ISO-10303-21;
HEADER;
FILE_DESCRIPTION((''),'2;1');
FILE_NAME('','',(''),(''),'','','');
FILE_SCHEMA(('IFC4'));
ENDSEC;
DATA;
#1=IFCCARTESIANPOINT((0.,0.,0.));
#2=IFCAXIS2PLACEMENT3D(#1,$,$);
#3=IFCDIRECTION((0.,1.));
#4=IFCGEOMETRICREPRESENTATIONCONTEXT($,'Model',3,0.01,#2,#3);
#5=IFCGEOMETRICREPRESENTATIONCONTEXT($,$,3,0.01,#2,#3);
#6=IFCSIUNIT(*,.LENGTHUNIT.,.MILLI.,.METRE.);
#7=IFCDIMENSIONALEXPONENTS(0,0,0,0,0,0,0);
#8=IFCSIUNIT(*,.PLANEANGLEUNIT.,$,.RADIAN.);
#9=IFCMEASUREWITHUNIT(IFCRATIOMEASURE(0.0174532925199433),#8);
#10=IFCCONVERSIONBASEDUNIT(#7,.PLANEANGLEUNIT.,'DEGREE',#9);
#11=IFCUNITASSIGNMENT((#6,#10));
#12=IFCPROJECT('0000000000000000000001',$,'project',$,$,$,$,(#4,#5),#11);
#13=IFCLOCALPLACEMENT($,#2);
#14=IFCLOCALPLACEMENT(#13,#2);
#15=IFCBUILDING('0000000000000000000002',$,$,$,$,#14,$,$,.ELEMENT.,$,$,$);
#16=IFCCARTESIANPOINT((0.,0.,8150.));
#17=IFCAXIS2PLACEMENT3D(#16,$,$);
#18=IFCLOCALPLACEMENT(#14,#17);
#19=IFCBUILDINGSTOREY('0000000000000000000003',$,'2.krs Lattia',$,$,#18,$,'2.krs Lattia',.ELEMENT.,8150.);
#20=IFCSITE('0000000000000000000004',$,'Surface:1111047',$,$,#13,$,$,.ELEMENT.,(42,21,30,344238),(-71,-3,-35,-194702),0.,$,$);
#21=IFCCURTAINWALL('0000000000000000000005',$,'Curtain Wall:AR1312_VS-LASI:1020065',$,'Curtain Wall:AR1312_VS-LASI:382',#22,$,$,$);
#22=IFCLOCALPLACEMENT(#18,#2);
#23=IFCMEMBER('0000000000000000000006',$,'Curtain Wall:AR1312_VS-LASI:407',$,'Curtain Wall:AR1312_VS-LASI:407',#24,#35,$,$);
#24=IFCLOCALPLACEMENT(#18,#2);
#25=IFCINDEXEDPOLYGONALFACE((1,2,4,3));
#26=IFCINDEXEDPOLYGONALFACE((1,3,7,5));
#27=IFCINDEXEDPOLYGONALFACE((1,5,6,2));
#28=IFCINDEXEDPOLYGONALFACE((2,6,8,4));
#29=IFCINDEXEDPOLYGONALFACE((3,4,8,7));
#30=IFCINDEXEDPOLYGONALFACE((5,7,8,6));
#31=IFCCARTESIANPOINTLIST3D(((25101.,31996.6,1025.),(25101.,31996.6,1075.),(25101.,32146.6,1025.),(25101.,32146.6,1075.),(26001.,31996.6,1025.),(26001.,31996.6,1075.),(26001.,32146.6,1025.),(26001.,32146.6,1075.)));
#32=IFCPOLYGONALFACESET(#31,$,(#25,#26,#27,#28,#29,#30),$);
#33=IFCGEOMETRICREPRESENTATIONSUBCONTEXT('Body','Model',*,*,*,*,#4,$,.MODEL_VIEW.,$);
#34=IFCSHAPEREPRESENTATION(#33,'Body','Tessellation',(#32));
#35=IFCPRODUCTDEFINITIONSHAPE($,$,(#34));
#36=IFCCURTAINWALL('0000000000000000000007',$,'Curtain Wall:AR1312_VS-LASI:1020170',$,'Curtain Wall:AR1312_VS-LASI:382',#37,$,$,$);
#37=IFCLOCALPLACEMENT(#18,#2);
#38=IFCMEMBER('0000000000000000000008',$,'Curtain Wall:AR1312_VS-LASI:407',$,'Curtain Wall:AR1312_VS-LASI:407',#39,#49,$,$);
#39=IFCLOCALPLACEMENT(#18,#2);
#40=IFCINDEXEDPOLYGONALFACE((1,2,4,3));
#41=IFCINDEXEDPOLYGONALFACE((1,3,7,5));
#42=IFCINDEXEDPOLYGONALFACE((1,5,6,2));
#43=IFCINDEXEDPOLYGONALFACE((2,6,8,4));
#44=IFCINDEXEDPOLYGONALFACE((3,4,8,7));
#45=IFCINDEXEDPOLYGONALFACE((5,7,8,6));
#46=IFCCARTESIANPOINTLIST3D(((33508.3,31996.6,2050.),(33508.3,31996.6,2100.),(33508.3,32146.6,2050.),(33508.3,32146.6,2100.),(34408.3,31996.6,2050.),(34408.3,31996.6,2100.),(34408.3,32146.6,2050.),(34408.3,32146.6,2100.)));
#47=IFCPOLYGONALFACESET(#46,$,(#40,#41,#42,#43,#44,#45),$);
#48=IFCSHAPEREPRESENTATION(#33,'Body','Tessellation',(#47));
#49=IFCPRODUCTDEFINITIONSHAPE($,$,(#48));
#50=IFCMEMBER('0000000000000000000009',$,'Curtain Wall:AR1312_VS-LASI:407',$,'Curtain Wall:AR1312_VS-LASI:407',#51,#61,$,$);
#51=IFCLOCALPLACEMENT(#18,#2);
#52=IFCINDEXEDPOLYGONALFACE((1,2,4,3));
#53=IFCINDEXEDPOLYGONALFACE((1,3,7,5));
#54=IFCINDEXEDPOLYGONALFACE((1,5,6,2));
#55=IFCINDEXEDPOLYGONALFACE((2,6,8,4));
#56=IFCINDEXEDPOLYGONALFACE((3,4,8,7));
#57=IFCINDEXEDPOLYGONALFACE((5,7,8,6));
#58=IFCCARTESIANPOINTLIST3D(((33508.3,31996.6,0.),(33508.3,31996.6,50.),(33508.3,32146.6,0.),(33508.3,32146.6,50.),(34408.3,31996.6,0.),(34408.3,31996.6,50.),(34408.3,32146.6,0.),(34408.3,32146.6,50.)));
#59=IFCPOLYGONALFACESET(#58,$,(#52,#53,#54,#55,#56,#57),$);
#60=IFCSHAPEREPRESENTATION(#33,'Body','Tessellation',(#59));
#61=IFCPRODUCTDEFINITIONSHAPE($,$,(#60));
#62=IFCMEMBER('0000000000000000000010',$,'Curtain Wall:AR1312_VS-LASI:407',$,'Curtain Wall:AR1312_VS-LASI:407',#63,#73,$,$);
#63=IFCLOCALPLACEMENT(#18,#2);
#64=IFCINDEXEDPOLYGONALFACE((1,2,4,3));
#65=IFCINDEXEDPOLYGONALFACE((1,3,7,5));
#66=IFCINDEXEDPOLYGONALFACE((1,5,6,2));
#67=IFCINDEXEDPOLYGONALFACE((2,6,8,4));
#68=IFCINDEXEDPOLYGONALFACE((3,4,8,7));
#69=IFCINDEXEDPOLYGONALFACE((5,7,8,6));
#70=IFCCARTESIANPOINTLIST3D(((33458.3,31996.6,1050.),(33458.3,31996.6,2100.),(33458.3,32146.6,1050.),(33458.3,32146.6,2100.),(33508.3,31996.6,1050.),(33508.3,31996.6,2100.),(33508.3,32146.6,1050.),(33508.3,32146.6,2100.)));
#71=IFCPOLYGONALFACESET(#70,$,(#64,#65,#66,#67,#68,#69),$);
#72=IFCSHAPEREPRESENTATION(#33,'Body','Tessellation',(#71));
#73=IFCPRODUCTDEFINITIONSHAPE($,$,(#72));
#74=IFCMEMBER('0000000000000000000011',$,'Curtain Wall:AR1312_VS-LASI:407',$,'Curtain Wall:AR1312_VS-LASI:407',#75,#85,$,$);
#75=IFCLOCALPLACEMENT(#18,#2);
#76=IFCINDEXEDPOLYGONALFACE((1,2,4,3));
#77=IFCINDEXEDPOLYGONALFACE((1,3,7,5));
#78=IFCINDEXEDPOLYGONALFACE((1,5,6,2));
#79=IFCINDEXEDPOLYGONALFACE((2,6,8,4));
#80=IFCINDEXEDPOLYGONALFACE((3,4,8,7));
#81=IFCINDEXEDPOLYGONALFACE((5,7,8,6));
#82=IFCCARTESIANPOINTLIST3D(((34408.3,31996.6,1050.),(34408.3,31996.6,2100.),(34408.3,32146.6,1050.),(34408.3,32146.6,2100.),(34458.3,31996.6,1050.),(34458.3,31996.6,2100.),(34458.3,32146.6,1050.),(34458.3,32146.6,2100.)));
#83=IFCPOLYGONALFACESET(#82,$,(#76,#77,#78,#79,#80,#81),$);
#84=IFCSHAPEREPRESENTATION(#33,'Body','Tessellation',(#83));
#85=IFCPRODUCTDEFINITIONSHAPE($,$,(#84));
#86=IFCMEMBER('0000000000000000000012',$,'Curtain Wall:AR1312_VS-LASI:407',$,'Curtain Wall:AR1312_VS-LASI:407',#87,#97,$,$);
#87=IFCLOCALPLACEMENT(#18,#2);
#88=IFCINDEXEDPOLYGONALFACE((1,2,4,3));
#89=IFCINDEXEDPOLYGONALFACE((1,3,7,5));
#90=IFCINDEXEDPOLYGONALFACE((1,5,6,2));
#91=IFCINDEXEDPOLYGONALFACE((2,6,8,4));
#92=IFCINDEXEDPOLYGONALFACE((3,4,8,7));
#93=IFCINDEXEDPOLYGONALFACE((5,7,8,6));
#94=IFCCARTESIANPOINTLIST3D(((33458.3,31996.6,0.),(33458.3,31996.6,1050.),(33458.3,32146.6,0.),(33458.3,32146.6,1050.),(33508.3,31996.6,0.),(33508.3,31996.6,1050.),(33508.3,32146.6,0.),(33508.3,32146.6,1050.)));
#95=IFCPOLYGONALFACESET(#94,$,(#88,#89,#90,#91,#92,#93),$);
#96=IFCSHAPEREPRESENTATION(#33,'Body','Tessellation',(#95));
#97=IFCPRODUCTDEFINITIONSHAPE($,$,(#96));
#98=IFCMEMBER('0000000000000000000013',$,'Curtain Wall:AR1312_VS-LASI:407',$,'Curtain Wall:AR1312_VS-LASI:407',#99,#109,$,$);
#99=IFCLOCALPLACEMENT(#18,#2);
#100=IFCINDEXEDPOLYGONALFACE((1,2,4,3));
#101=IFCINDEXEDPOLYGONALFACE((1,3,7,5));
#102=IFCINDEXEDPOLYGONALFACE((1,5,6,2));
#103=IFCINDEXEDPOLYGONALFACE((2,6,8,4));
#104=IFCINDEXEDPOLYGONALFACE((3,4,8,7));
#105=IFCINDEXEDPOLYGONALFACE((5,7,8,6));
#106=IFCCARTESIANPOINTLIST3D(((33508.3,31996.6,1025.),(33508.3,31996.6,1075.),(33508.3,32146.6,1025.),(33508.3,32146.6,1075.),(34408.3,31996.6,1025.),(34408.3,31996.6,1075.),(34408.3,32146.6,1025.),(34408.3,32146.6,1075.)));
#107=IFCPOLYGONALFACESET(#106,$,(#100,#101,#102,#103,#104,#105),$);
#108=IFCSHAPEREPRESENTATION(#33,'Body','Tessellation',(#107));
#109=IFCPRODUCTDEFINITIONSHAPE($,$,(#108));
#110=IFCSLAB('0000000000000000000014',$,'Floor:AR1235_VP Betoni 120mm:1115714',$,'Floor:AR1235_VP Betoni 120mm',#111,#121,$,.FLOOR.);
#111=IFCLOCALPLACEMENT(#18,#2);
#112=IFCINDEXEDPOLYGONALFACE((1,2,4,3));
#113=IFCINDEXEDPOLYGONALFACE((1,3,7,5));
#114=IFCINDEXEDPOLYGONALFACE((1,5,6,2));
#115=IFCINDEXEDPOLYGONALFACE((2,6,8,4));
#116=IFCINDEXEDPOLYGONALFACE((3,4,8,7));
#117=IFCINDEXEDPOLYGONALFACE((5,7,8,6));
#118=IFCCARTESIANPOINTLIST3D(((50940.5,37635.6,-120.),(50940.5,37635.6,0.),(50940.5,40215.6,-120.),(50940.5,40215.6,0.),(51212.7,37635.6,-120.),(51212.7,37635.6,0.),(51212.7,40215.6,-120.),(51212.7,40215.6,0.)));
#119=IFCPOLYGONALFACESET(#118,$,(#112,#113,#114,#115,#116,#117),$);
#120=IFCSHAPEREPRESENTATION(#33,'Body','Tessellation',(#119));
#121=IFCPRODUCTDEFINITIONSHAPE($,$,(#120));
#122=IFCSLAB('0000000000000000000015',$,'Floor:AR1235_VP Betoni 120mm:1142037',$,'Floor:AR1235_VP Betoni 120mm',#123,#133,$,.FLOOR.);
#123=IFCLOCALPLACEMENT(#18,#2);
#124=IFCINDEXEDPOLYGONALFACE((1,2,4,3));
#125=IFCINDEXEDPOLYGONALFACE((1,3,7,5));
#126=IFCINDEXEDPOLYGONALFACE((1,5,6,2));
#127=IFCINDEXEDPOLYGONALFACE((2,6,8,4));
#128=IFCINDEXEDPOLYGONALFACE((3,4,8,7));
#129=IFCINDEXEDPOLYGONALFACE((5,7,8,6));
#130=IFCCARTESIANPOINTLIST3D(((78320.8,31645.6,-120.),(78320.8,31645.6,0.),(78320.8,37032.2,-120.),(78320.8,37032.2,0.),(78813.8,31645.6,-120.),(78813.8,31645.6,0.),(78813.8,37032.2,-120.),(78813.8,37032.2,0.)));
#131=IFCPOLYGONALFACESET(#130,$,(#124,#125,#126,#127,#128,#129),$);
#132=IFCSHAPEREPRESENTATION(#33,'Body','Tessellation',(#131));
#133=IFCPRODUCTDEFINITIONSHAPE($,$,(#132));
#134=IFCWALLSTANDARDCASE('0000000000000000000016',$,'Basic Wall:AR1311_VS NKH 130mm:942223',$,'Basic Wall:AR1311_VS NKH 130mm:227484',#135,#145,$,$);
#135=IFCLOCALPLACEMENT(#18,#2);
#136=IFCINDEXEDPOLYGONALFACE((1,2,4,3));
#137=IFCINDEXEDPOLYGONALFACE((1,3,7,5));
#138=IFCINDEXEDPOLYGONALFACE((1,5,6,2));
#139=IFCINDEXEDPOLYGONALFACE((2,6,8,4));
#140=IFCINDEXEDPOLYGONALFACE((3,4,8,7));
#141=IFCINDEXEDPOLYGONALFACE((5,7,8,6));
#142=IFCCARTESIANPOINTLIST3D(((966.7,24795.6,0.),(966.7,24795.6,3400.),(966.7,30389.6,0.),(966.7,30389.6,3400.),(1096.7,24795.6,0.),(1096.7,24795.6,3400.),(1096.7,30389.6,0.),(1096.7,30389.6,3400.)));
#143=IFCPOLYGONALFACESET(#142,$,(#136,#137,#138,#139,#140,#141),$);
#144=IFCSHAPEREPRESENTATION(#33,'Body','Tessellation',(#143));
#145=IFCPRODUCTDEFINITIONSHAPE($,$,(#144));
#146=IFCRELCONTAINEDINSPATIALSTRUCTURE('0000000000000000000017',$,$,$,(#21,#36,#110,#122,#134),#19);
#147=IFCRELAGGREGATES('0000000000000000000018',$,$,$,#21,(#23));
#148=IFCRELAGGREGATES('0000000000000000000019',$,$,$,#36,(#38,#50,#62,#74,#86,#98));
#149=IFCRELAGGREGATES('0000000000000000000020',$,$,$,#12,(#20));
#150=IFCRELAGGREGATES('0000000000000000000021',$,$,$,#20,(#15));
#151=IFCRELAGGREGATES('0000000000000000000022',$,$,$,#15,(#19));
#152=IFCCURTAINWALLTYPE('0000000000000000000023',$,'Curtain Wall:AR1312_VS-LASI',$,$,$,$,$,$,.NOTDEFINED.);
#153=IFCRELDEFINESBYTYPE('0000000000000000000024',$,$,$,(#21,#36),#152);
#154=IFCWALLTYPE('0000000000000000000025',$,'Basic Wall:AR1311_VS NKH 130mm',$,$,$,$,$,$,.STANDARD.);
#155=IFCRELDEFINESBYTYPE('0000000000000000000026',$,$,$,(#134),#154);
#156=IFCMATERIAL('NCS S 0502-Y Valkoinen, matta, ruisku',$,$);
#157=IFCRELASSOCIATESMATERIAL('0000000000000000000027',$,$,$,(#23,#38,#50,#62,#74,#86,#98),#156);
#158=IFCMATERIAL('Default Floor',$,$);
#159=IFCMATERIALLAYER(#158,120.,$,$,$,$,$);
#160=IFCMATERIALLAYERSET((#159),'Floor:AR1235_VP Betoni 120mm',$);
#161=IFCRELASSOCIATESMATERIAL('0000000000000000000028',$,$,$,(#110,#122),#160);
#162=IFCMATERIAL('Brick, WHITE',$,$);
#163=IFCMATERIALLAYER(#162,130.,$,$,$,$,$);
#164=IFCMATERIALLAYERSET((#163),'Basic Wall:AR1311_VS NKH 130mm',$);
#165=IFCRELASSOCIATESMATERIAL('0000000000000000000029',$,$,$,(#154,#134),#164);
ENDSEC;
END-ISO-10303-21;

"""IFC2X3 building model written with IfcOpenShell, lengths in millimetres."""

from ifc_helpers import new_model, entity, si_unit, converted_unit, direction, frame, frame_2d, origin, place, context, subcontext, project, spatial, rectangle, extrude, material, layer, layer_set, layer_usage, type_object, element, aggregate, save


model = new_model("IFC2X3")

# Units and contexts
model_context = context("Model", 3, precision=0.01, world=origin(), true_north=direction((0.0, 1.0)))
context_of_model = context(None, 3, precision=0.01, world=origin(), true_north=direction((0.0, 1.0)))
body_context = subcontext(model_context, "Body", "Model", "MODEL_VIEW")
ifc_project = project(units=[si_unit("LENGTHUNIT", "METRE", prefix="MILLI"), converted_unit("PLANEANGLEUNIT", "DEGREE", entity("IfcRatioMeasure", 0.0174532925199433), si_unit("PLANEANGLEUNIT", "RADIAN"), dimensions=[0, 0, 0, 0, 0, 0, 0])], contexts=[model_context, context_of_model])

# Site, building, storey
site_placement = place(None, origin())
site = spatial("IfcSite", under=ifc_project, at=site_placement, Name="Surface:1111047", CompositionType="ELEMENT", RefLatitude=(42, 21, 30, 344238), RefLongitude=(-71, -3, -35, -194702), RefElevation=0.0)
building_placement = place(site_placement, origin())
building = spatial("IfcBuilding", under=site, at=building_placement, CompositionType="ELEMENT")
storey_placement = place(building_placement, frame((0.0, 0.0, 8150.0)))
storey = spatial("IfcBuildingStorey", under=building, at=storey_placement, Name="2.krs Lattia", LongName="2.krs Lattia", CompositionType="ELEMENT", Elevation=8150.0)

# Curtain walls, members
curtain_wall_type = type_object("IfcCurtainWallType", Name="Curtain Wall:AR1312_VS-LASI", PredefinedType="NOTDEFINED")
ifc_material_1 = material(Name="NCS S 0502-Y Valkoinen, matta, ruisku")
curtain_wall_1_placement = place(storey_placement, frame((0.0, 0.0, -8150.0)))
curtain_wall_1 = element("IfcCurtainWall", 1, at=curtain_wall_1_placement, inside=storey, type_object=curtain_wall_type, Name="Curtain Wall:AR1312_VS-LASI:1020065", ObjectType="Curtain Wall:AR1312_VS-LASI:382")
member_1_placement = place(curtain_wall_1_placement, frame((0.0, 0.0, 8150.0)))
member_1 = element("IfcMember", 2, at=member_1_placement, material=ifc_material_1, Name="Curtain Wall:AR1312_VS-LASI:407", ObjectType="Curtain Wall:AR1312_VS-LASI:407", context=body_context, shape_type="SweptSolid", body=[
    extrude(rectangle(XDim=50.0, YDim=150.0, at=frame_2d((0.0, 0.0), x_axis=(1.0, 0.0))), frame((26001.0, 32071.6, 1050.0), z_axis=(-1.0, 0.0, 0.0), x_axis=(0.0, 0.0, -1.0)), (0.0, 0.0, 1.0), 900.0),
])
aggregate(curtain_wall_1, [member_1])
curtain_wall_2_placement = place(storey_placement, frame((0.0, 0.0, -8150.0)))
curtain_wall_2 = element("IfcCurtainWall", 3, at=curtain_wall_2_placement, inside=storey, type_object=curtain_wall_type, Name="Curtain Wall:AR1312_VS-LASI:1020170", ObjectType="Curtain Wall:AR1312_VS-LASI:382")
member_2_placement = place(curtain_wall_2_placement, frame((0.0, 0.0, 8150.0)))
member_2 = element("IfcMember", 4, at=member_2_placement, material=ifc_material_1, Name="Curtain Wall:AR1312_VS-LASI:407", ObjectType="Curtain Wall:AR1312_VS-LASI:407", context=body_context, shape_type="SweptSolid", body=[
    extrude(rectangle(XDim=50.0, YDim=150.0, at=frame_2d((0.0, 0.0), x_axis=(1.0, 0.0))), frame((34408.3, 32071.6, 2075.0), z_axis=(-1.0, 0.0, 0.0), x_axis=(0.0, 0.0, -1.0)), (0.0, 0.0, 1.0), 900.0),
])
member_3_placement = place(curtain_wall_2_placement, frame((0.0, 0.0, 8150.0)))
member_3 = element("IfcMember", 5, at=member_3_placement, material=ifc_material_1, Name="Curtain Wall:AR1312_VS-LASI:407", ObjectType="Curtain Wall:AR1312_VS-LASI:407", context=body_context, shape_type="SweptSolid", body=[
    extrude(rectangle(XDim=50.0, YDim=150.0, at=frame_2d((0.0, 0.0), x_axis=(1.0, 0.0))), frame((33508.3, 32071.6, 25.0), z_axis=(1.0, 0.0, 0.0), x_axis=(0.0, 0.0, -1.0)), (0.0, 0.0, 1.0), 900.0),
])
member_4_placement = place(curtain_wall_2_placement, frame((0.0, 0.0, 8150.0)))
member_4 = element("IfcMember", 6, at=member_4_placement, material=ifc_material_1, Name="Curtain Wall:AR1312_VS-LASI:407", ObjectType="Curtain Wall:AR1312_VS-LASI:407", context=body_context, shape_type="SweptSolid", body=[
    extrude(rectangle(XDim=50.0, YDim=150.0, at=frame_2d((0.0, 0.0), x_axis=(1.0, 0.0))), frame((33483.3, 32071.6, 2100.0), z_axis=(0.0, 0.0, -1.0), x_axis=(-1.0, 0.0, 0.0)), (0.0, 0.0, 1.0), 1050.0),
])
member_5_placement = place(curtain_wall_2_placement, frame((0.0, 0.0, 8150.0)))
member_5 = element("IfcMember", 7, at=member_5_placement, material=ifc_material_1, Name="Curtain Wall:AR1312_VS-LASI:407", ObjectType="Curtain Wall:AR1312_VS-LASI:407", context=body_context, shape_type="SweptSolid", body=[
    extrude(rectangle(XDim=50.0, YDim=150.0, at=frame_2d((0.0, 0.0), x_axis=(1.0, 0.0))), frame((34433.3, 32071.6, 1050.0), z_axis=(0.0, 0.0, 1.0), x_axis=(-1.0, 0.0, 0.0)), (0.0, 0.0, 1.0), 1050.0),
])
member_6_placement = place(curtain_wall_2_placement, frame((0.0, 0.0, 8150.0)))
member_6 = element("IfcMember", 8, at=member_6_placement, material=ifc_material_1, Name="Curtain Wall:AR1312_VS-LASI:407", ObjectType="Curtain Wall:AR1312_VS-LASI:407", context=body_context, shape_type="SweptSolid", body=[
    extrude(rectangle(XDim=50.0, YDim=150.0, at=frame_2d((0.0, 0.0), x_axis=(1.0, 0.0))), frame((33483.3, 32071.6, 1050.0), z_axis=(0.0, 0.0, -1.0), x_axis=(-1.0, 0.0, 0.0)), (0.0, 0.0, 1.0), 1050.0),
])
member_7_placement = place(curtain_wall_2_placement, frame((0.0, 0.0, 8150.0)))
member_7 = element("IfcMember", 9, at=member_7_placement, material=ifc_material_1, Name="Curtain Wall:AR1312_VS-LASI:407", ObjectType="Curtain Wall:AR1312_VS-LASI:407", context=body_context, shape_type="SweptSolid", body=[
    extrude(rectangle(XDim=50.0, YDim=150.0, at=frame_2d((0.0, 0.0), x_axis=(1.0, 0.0))), frame((34408.3, 32071.6, 1050.0), z_axis=(-1.0, 0.0, 0.0), x_axis=(0.0, 0.0, -1.0)), (0.0, 0.0, 1.0), 900.0),
])
aggregate(curtain_wall_2, [member_2, member_3, member_4, member_5, member_6, member_7])

# Slabs
ifc_material_2 = material(Name="Default Floor")
ifc_layer_1 = layer(ifc_material_2, 120.0)
ifc_layer_set_1 = layer_set([ifc_layer_1], Name="Floor:AR1235_VP Betoni 120mm")
ifc_layer_usage_1 = layer_usage(ifc_layer_set_1, "AXIS3", "POSITIVE", 0.0)
slab_1_placement = place(storey_placement, origin())
element("IfcSlab", 10, at=slab_1_placement, inside=storey, material=ifc_layer_usage_1, Name="Floor:AR1235_VP Betoni 120mm:1115714", ObjectType="Floor:AR1235_VP Betoni 120mm", PredefinedType="FLOOR", context=body_context, shape_type="SweptSolid", body=[
    extrude(rectangle(XDim=2580.0, YDim=272.2, at=frame_2d((0.0, 0.0), x_axis=(1.0, 0.0))), frame((51076.6, 38925.6, 0.0), z_axis=(0.0, 0.0, -1.0), x_axis=(0.0, 1.0, 0.0)), (0.0, 0.0, 1.0), 120.0),
])
ifc_layer_usage_2 = layer_usage(ifc_layer_set_1, "AXIS3", "POSITIVE", 0.0)
slab_2_placement = place(storey_placement, origin())
element("IfcSlab", 11, at=slab_2_placement, inside=storey, material=ifc_layer_usage_2, Name="Floor:AR1235_VP Betoni 120mm:1142037", ObjectType="Floor:AR1235_VP Betoni 120mm", PredefinedType="FLOOR", context=body_context, shape_type="SweptSolid", body=[
    extrude(rectangle(XDim=5386.6, YDim=493.0, at=frame_2d((0.0, 0.0), x_axis=(1.0, 0.0))), frame((78567.3, 34338.9, 0.0), z_axis=(0.0, 0.0, -1.0), x_axis=(0.0, 1.0, 0.0)), (0.0, 0.0, 1.0), 120.0),
])

# Wall
ifc_material_3 = material(Name="Brick, WHITE")
ifc_layer_2 = layer(ifc_material_3, 130.0)
ifc_layer_set_2 = layer_set([ifc_layer_2], Name="Basic Wall:AR1311_VS NKH 130mm")
ifc_layer_usage_3 = layer_usage(ifc_layer_set_2, "AXIS2", "NEGATIVE", 65.0)
wall_type = type_object("IfcWallType", Name="Basic Wall:AR1311_VS NKH 130mm", PredefinedType="STANDARD", material=ifc_layer_set_2)
wall_placement = place(storey_placement, frame((1031.7, 30389.6, 0.0), z_axis=(0.0, 0.0, 1.0), x_axis=(0.0, -1.0, 0.0)))
element("IfcWallStandardCase", 12, at=wall_placement, inside=storey, type_object=wall_type, material=ifc_layer_usage_3, Name="Basic Wall:AR1311_VS NKH 130mm:942223", ObjectType="Basic Wall:AR1311_VS NKH 130mm:227484", context=body_context, shape_type="SweptSolid", body=[
    extrude(rectangle(XDim=5594.0, YDim=130.0, at=frame_2d((2797.0, 0.0), x_axis=(-1.0, 0.0))), origin(), (0.0, 0.0, 1.0), 3400.0),
])

save(model, "model.ifc")
